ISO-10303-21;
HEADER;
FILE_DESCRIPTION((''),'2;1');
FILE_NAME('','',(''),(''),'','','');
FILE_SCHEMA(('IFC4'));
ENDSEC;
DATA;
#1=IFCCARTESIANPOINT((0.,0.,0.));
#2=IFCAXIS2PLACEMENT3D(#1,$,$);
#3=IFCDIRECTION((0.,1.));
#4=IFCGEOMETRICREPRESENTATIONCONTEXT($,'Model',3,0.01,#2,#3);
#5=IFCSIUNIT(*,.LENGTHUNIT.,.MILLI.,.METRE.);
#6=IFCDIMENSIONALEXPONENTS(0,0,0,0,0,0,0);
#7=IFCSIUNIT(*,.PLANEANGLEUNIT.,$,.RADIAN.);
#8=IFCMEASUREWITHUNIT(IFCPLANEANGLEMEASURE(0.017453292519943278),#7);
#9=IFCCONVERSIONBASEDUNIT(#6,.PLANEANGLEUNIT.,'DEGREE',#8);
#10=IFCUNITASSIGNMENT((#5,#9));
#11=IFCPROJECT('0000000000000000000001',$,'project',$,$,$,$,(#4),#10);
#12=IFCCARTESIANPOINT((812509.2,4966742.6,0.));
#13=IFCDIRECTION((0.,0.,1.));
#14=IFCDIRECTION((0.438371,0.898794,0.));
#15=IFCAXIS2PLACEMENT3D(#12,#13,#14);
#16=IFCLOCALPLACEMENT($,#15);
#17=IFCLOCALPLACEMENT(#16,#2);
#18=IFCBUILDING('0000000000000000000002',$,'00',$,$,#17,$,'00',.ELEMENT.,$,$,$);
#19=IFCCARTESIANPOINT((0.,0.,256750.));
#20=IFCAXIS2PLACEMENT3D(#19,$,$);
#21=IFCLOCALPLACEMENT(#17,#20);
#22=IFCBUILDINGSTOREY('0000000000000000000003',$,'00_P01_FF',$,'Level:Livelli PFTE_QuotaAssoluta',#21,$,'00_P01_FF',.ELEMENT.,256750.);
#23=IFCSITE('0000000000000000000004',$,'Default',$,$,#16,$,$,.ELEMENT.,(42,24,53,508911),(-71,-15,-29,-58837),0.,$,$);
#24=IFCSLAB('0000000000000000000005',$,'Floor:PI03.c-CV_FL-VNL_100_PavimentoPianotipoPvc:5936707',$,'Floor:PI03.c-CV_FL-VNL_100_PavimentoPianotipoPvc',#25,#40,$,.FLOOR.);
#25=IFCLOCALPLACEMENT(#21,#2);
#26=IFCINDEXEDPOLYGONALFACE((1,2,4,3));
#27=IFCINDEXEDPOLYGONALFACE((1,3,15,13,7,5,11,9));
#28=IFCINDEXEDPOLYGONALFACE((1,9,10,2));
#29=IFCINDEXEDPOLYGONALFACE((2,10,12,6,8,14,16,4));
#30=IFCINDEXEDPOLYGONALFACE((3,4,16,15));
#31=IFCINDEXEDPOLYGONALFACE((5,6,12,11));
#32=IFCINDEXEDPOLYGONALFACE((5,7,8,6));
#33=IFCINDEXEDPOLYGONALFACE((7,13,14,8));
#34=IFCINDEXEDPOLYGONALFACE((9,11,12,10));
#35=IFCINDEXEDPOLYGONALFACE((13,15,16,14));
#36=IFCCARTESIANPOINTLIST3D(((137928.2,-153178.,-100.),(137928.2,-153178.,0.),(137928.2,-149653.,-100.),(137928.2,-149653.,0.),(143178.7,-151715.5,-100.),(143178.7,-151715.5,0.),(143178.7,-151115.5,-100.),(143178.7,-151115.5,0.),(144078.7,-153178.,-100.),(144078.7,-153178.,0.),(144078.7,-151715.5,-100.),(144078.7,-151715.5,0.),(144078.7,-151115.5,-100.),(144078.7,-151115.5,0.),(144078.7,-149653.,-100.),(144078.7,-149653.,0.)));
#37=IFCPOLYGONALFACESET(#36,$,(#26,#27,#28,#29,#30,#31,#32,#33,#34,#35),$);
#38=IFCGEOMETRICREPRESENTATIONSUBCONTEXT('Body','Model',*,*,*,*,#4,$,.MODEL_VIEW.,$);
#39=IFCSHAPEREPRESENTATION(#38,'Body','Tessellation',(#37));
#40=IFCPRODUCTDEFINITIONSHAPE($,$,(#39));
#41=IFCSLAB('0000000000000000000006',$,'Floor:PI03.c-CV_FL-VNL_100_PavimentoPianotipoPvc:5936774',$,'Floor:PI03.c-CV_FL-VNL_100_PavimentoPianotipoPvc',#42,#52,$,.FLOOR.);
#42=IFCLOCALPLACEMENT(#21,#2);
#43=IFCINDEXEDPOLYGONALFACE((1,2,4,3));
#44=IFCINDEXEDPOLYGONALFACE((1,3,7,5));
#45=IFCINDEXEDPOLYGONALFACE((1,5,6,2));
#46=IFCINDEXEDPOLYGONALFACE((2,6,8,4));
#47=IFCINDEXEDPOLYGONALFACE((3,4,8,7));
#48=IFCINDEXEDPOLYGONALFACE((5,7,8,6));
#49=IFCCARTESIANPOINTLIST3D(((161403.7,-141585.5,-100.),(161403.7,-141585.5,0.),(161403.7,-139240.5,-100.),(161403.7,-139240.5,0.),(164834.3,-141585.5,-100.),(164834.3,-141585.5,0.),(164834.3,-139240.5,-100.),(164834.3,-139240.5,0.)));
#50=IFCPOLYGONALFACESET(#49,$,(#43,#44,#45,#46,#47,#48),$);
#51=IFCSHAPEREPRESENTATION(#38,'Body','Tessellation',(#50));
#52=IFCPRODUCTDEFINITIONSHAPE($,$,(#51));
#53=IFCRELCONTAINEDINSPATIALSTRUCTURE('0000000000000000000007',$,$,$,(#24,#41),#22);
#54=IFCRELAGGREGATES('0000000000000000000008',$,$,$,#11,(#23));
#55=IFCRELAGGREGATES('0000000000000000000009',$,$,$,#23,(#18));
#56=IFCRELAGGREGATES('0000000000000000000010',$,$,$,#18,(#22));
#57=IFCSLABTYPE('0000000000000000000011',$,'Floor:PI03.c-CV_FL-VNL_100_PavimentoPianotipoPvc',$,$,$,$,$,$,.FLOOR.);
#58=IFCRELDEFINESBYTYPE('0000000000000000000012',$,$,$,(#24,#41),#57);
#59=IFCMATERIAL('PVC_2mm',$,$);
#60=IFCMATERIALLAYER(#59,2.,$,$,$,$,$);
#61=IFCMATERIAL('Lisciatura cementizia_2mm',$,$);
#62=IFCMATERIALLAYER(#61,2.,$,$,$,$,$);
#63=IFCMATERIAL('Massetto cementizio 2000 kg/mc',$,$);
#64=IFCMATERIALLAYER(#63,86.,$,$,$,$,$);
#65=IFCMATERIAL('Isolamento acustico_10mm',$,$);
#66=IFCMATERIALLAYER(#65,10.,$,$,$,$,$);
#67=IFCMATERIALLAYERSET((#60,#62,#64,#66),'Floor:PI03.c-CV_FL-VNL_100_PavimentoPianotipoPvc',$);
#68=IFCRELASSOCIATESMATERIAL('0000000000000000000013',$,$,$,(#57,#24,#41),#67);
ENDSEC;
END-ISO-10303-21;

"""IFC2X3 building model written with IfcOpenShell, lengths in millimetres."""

from ifc_helpers import new_model, entity, si_unit, converted_unit, direction, frame, frame_2d, origin, place, context, subcontext, project, spatial, polyline, rectangle, outline, extrude, material, layer, layer_set, layer_usage, type_object, element, save


model = new_model("IFC2X3")

# Units and contexts
model_context = context("Model", 3, precision=0.01, world=origin(), true_north=direction((0.0, 1.0)))
body_context = subcontext(model_context, "Body", "Model", "MODEL_VIEW")
ifc_project = project(units=[si_unit("LENGTHUNIT", "METRE", prefix="MILLI"), converted_unit("PLANEANGLEUNIT", "DEGREE", entity("IfcPlaneAngleMeasure", 0.017453292519943278), si_unit("PLANEANGLEUNIT", "RADIAN"), dimensions=[0, 0, 0, 0, 0, 0, 0])], contexts=[model_context])

# Site, building, storey
site_placement = place(None, frame((812509.2, 4966742.6, 0.0), z_axis=(0.0, 0.0, 1.0), x_axis=(0.438371, 0.898794, 0.0)))
site = spatial("IfcSite", under=ifc_project, at=site_placement, Name="Default", CompositionType="ELEMENT", RefLatitude=(42, 24, 53, 508911), RefLongitude=(-71, -15, -29, -58837), RefElevation=0.0)
building_placement = place(site_placement, origin())
building = spatial("IfcBuilding", under=site, at=building_placement, Name="00", LongName="00", CompositionType="ELEMENT")
storey_placement = place(building_placement, frame((0.0, 0.0, 256750.0)))
storey = spatial("IfcBuildingStorey", under=building, at=storey_placement, Name="00_P01_FF", ObjectType="Level:Livelli PFTE_QuotaAssoluta", LongName="00_P01_FF", CompositionType="ELEMENT", Elevation=256750.0)

# Slabs
ifc_material_1 = material(Name="PVC_2mm")
ifc_layer_1 = layer(ifc_material_1, 2.0)
ifc_material_2 = material(Name="Lisciatura cementizia_2mm")
ifc_layer_2 = layer(ifc_material_2, 2.0)
ifc_material_3 = material(Name="Massetto cementizio 2000 kg/mc")
ifc_layer_3 = layer(ifc_material_3, 86.0)
ifc_material_4 = material(Name="Isolamento acustico_10mm")
ifc_layer_4 = layer(ifc_material_4, 10.0)
ifc_layer_set_1 = layer_set([ifc_layer_1, ifc_layer_2, ifc_layer_3, ifc_layer_4], Name="Floor:PI03.c-CV_FL-VNL_100_PavimentoPianotipoPvc")
slab_type_1 = type_object("IfcSlabType", Name="Floor:PI03.c-CV_FL-VNL_100_PavimentoPianotipoPvc", PredefinedType="FLOOR", material=ifc_layer_set_1)
ifc_layer_usage_1 = layer_usage(ifc_layer_set_1, "AXIS3", "POSITIVE", 0.0)
slab_1_placement = place(storey_placement, origin())
element("IfcSlab", 1, at=slab_1_placement, inside=storey, type_object=slab_type_1, material=ifc_layer_usage_1, Name="Floor:PI03.c-CV_FL-VNL_100_PavimentoPianotipoPvc:5936707", ObjectType="Floor:PI03.c-CV_FL-VNL_100_PavimentoPianotipoPvc", PredefinedType="FLOOR", context=body_context, shape_type="SweptSolid", body=[
    extrude(outline(polyline([(-1762.5, -4387.9), (1762.5, -4387.9), (1762.5, 1762.6), (300.0, 1762.6), (300.0, 862.6), (-300.0, 862.6), (-300.0, 1762.6), (-1762.5, 1762.6), (-1762.5, -4387.9)])), frame((142316.1, -151415.5, 0.0), z_axis=(0.0, 0.0, -1.0), x_axis=(0.0, 1.0, 0.0)), (0.0, 0.0, 1.0), 100.0),
])
ifc_layer_usage_2 = layer_usage(ifc_layer_set_1, "AXIS3", "POSITIVE", 0.0)
slab_2_placement = place(storey_placement, origin())
element("IfcSlab", 2, at=slab_2_placement, inside=storey, type_object=slab_type_1, material=ifc_layer_usage_2, Name="Floor:PI03.c-CV_FL-VNL_100_PavimentoPianotipoPvc:5936774", ObjectType="Floor:PI03.c-CV_FL-VNL_100_PavimentoPianotipoPvc", PredefinedType="FLOOR", context=body_context, shape_type="SweptSolid", body=[
    extrude(rectangle(XDim=2345.0, YDim=3430.6, at=frame_2d((0.0, 0.0), x_axis=(1.0, 0.0))), frame((163119.0, -140413.0, 0.0), z_axis=(0.0, 0.0, -1.0), x_axis=(0.0, 1.0, 0.0)), (0.0, 0.0, 1.0), 100.0),
])

save(model, "model.ifc")
